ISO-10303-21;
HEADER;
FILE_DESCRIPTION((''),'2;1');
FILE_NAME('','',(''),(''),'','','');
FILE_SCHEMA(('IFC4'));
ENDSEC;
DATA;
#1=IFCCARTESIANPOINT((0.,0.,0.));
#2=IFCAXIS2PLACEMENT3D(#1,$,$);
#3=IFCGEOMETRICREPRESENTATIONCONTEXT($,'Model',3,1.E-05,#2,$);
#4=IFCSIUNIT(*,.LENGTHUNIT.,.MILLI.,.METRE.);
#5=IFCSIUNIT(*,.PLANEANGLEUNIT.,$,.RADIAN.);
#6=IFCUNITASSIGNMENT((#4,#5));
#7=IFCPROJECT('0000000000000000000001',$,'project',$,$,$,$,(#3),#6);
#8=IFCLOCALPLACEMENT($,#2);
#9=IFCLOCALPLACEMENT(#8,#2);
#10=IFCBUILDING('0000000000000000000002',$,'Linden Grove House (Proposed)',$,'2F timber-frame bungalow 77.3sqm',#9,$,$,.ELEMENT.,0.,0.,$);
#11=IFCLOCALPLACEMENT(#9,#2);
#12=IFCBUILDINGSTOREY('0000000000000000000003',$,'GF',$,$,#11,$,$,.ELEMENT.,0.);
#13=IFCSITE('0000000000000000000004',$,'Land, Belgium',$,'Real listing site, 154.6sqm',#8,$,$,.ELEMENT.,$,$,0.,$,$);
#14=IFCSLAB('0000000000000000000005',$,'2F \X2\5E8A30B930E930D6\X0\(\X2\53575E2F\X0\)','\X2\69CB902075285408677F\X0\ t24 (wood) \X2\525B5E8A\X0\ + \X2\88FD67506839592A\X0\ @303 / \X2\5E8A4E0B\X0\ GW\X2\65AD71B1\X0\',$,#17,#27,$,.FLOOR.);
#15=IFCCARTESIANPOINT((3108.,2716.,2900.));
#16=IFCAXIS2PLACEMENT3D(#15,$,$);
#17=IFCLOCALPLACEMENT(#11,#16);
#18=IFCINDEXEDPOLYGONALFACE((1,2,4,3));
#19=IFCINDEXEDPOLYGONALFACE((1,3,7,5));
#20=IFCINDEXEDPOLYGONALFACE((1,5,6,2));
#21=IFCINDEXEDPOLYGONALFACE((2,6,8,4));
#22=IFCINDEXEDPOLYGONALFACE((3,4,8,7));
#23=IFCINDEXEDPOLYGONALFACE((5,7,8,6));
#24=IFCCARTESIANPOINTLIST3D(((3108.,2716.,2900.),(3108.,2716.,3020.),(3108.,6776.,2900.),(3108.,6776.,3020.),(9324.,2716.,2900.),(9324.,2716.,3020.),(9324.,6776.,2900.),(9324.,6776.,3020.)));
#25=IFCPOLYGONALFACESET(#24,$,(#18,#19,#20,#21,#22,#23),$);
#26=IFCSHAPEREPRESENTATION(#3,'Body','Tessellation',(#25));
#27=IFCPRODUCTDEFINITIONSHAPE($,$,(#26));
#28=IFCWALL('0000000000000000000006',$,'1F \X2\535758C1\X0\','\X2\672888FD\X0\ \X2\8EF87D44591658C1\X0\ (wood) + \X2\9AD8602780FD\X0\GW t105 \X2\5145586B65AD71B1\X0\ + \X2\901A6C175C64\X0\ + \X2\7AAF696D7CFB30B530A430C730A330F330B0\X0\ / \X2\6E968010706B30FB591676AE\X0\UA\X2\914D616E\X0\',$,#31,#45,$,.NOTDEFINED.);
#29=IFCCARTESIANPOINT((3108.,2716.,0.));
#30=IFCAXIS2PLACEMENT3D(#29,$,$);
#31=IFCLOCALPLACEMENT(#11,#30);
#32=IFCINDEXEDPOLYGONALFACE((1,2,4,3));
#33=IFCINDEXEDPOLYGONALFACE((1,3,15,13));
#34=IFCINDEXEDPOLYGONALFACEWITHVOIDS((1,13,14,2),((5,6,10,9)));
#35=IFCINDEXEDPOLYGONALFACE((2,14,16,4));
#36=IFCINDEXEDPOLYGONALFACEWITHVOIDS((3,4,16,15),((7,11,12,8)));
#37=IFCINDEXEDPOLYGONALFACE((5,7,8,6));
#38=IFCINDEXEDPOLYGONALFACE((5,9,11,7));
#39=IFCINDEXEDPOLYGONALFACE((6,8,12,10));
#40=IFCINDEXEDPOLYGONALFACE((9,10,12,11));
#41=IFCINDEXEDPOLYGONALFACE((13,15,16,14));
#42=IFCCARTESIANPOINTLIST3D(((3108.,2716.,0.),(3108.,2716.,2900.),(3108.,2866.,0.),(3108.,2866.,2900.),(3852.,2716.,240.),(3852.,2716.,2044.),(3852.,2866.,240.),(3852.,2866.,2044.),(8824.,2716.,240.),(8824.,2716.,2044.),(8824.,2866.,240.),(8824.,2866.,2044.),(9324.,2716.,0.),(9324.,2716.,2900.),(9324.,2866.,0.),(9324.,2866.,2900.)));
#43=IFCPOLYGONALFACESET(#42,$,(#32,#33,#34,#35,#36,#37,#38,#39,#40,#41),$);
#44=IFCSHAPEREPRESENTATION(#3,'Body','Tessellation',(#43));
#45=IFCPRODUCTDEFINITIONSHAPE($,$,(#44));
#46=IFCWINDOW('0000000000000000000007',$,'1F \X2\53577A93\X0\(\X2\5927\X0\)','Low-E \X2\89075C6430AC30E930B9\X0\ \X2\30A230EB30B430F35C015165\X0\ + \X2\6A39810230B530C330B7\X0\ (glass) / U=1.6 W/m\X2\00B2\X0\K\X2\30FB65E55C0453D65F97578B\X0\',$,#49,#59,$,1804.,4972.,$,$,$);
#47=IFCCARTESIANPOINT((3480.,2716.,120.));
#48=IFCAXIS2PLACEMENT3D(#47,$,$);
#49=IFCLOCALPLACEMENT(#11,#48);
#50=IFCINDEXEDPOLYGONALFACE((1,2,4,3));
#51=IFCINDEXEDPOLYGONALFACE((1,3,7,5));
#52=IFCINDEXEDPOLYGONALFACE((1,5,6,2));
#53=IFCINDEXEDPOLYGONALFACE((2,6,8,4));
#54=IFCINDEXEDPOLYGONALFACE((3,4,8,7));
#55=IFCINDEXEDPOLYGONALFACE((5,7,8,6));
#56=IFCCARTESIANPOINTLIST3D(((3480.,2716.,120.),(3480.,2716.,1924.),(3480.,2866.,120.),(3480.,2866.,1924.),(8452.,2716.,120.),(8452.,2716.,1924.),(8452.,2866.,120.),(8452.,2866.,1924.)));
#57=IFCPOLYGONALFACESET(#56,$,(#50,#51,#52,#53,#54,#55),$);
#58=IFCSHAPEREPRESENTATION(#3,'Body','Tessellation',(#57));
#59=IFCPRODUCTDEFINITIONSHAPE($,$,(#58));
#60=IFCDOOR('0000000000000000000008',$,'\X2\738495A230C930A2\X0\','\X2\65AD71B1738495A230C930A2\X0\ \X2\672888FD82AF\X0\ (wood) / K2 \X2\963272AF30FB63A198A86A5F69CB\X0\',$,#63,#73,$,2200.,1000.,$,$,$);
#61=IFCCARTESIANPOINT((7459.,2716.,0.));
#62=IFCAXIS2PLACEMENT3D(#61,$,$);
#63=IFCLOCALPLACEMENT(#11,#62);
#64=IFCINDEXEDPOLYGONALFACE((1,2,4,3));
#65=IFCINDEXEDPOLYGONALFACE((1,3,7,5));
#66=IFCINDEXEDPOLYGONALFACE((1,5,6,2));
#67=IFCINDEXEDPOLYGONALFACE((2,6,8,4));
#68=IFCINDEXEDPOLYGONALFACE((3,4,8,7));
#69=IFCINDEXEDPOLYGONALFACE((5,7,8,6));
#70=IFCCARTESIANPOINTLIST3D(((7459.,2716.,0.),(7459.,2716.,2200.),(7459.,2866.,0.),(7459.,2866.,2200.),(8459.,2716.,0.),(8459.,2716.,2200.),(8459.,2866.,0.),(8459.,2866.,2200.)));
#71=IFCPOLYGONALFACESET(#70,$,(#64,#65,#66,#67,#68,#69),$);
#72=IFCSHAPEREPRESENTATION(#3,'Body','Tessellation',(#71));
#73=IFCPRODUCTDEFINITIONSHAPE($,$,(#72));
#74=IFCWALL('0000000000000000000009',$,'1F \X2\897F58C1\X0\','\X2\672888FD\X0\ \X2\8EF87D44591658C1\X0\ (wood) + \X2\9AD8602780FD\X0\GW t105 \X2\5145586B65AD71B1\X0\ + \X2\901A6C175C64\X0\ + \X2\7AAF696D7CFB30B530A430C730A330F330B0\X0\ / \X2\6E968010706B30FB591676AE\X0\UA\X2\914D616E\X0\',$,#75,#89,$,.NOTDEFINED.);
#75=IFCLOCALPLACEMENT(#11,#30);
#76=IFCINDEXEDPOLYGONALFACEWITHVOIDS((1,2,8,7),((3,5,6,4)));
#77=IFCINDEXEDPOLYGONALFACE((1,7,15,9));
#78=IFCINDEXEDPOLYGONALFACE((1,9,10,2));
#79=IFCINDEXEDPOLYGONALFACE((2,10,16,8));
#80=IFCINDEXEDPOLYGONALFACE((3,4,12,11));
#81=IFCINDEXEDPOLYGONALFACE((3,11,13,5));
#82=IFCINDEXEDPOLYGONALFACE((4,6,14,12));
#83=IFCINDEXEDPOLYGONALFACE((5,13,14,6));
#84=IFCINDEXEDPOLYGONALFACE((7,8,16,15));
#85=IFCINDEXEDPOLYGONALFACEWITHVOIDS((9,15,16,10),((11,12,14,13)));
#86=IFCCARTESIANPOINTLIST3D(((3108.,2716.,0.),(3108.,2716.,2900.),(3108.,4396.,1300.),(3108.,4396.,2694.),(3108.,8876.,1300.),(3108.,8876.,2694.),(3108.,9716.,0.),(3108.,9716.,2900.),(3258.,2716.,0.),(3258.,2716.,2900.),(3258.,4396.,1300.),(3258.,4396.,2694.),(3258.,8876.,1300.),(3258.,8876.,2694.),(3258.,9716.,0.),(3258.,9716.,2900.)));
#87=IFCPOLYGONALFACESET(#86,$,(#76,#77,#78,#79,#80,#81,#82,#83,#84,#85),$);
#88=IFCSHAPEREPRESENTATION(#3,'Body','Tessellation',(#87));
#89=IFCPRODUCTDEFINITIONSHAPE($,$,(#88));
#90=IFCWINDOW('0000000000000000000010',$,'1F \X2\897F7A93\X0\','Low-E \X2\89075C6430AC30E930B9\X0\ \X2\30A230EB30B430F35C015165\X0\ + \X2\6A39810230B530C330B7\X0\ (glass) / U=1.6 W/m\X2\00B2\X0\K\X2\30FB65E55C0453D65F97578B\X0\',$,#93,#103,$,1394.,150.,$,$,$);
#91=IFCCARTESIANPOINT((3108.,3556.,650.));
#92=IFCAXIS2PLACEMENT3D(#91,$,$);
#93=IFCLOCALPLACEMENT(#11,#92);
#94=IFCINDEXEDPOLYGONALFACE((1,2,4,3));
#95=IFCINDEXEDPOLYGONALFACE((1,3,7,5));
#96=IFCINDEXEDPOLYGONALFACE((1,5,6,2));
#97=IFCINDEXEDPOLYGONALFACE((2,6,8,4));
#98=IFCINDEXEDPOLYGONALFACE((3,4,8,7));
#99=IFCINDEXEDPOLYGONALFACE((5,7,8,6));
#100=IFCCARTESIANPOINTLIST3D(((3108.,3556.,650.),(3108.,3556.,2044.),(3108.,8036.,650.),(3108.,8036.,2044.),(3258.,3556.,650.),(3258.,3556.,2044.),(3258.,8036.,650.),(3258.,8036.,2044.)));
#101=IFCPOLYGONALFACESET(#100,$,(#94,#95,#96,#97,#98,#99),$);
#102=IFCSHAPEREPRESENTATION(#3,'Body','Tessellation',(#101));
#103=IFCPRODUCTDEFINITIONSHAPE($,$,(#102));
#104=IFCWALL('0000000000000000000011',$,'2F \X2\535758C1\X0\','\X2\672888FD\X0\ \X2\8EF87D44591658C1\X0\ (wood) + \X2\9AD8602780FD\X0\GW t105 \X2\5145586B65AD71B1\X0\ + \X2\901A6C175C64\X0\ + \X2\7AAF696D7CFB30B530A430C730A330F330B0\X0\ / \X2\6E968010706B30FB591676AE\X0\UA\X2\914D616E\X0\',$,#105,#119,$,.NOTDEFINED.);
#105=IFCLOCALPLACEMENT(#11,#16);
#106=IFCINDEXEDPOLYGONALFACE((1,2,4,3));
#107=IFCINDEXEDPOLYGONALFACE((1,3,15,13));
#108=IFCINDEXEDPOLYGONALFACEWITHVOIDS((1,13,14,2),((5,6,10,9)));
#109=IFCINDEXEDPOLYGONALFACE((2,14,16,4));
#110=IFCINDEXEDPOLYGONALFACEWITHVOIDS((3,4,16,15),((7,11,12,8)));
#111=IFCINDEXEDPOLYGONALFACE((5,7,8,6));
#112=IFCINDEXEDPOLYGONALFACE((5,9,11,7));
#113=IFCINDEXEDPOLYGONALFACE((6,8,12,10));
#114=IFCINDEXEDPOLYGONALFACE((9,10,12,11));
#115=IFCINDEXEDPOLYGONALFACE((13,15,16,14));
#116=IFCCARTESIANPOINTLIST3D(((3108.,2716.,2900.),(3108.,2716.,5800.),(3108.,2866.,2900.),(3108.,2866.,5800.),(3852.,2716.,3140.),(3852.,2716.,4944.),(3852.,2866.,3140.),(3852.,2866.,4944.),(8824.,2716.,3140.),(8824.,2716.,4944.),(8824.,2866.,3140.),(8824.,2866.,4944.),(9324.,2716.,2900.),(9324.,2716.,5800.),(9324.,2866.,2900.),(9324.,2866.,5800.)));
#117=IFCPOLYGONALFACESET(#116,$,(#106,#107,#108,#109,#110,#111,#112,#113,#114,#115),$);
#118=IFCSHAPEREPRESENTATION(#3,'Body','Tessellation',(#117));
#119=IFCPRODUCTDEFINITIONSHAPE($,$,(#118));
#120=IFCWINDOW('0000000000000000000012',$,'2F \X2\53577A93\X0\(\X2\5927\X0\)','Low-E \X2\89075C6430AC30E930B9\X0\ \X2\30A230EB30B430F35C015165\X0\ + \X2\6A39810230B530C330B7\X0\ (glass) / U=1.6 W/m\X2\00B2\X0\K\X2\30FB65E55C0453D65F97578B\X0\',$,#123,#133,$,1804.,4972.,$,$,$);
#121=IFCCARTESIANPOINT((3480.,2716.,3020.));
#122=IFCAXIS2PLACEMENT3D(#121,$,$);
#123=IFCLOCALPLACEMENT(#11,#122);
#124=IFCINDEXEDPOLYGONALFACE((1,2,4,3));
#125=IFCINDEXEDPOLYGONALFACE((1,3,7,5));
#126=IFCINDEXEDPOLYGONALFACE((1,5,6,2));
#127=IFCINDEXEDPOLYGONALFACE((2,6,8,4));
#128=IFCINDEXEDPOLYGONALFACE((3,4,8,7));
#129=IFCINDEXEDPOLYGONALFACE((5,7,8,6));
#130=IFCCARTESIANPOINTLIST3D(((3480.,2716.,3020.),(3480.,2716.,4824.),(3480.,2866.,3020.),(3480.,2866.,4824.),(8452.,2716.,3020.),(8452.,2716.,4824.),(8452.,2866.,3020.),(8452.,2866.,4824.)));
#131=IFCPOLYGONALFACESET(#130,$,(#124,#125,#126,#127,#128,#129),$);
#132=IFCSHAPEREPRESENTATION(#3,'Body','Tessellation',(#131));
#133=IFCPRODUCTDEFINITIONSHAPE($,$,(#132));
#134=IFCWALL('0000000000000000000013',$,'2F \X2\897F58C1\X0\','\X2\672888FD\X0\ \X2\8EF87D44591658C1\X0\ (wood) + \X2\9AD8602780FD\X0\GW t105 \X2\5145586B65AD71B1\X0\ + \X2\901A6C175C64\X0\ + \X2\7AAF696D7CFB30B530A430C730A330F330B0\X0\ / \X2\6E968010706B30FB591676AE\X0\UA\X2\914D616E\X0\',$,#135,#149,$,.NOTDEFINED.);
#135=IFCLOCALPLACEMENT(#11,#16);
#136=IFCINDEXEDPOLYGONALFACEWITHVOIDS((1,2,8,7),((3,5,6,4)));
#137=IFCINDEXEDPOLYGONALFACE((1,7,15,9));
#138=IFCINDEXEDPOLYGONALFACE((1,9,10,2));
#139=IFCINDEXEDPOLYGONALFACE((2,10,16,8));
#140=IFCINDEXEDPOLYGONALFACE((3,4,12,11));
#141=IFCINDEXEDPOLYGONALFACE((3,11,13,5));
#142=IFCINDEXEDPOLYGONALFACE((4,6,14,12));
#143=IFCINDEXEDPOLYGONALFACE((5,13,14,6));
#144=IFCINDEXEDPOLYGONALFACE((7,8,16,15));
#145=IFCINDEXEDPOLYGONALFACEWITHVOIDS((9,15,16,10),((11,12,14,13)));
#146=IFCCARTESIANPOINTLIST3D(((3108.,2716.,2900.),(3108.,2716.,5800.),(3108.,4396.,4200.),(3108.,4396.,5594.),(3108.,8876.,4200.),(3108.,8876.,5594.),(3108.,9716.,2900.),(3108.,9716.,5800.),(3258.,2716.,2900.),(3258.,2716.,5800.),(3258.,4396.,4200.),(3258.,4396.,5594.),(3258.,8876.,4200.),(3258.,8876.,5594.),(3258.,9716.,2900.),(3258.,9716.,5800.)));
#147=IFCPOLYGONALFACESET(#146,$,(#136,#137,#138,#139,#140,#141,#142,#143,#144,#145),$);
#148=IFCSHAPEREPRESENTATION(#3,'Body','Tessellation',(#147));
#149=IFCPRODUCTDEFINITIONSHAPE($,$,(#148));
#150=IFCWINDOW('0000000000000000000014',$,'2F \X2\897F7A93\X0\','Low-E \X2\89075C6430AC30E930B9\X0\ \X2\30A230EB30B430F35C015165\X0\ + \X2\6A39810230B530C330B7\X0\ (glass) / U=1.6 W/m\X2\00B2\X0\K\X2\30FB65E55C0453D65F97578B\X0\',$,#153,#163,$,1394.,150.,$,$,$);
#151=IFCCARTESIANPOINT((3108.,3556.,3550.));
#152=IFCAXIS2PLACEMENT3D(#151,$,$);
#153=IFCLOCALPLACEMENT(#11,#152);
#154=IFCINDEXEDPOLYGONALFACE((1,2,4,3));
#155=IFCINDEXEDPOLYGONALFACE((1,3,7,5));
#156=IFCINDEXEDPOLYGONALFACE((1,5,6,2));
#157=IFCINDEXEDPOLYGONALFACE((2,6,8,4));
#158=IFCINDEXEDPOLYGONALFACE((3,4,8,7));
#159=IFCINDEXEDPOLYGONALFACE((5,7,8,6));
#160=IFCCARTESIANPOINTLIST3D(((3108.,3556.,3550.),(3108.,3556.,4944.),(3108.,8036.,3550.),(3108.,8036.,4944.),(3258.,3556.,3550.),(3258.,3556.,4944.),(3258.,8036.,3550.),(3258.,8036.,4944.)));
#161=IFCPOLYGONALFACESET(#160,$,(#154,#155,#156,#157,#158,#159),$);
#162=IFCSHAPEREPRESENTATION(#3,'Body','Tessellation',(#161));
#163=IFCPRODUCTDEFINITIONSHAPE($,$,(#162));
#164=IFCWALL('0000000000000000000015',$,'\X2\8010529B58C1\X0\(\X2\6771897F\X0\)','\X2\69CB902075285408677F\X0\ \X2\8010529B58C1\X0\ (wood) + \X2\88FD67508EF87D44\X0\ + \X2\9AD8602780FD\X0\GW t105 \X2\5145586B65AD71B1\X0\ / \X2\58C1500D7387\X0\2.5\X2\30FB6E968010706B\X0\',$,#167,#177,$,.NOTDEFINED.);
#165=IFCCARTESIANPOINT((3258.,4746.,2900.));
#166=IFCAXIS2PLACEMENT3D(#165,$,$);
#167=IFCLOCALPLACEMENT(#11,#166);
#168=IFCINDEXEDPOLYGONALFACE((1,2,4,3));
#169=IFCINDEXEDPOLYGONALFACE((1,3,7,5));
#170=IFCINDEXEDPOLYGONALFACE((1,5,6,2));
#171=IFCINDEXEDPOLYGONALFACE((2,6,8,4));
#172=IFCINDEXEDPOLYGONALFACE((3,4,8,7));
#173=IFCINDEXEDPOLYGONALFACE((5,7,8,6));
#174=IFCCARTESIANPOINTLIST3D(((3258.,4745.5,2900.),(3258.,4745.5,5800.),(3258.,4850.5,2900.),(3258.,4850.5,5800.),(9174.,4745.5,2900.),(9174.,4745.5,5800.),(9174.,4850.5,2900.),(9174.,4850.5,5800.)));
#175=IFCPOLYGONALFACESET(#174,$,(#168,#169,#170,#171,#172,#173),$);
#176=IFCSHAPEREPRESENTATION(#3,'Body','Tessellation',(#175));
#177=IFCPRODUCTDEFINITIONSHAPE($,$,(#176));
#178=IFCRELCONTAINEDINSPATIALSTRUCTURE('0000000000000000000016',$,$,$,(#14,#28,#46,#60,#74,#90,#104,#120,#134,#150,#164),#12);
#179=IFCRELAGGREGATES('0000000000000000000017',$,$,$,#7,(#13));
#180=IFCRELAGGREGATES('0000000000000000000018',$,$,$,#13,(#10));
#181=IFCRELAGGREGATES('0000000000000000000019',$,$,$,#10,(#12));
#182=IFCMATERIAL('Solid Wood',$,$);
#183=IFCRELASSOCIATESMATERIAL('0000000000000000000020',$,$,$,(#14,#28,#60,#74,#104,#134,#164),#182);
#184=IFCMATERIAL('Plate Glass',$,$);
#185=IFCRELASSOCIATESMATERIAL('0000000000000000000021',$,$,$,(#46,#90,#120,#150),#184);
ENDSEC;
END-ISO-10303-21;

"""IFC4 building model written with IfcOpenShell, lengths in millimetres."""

from ifc_helpers import new_model, si_unit, frame, frame_2d, origin, place, context, project, spatial, rectangle, extrude, material, element, fill, save


model = new_model("IFC4")

# Units and contexts
model_context = context("Model", 3, precision=1e-05, world=origin())
ifc_project = project(units=[si_unit("LENGTHUNIT", "METRE", prefix="MILLI"), si_unit("PLANEANGLEUNIT", "RADIAN")], contexts=[model_context])

# Site, building, storey
site_placement = place(None, origin())
site = spatial("IfcSite", under=ifc_project, at=site_placement, Name="Land, Belgium", ObjectType="Real listing site, 154.6sqm", CompositionType="ELEMENT", RefElevation=0.0)
building_placement = place(site_placement, origin())
building = spatial("IfcBuilding", under=site, at=building_placement, Name="Linden Grove House (Proposed)", ObjectType="2F timber-frame bungalow 77.3sqm", CompositionType="ELEMENT", ElevationOfRefHeight=0.0, ElevationOfTerrain=0.0)
storey_placement = place(building_placement, origin())
storey = spatial("IfcBuildingStorey", under=building, at=storey_placement, Name="GF", CompositionType="ELEMENT", Elevation=0.0)

# Slab
ifc_material_1 = material(Name="Solid Wood")
slab_1_placement = place(storey_placement, frame((3108.0, 2716.0, 2900.0)))
element("IfcSlab", 1, at=slab_1_placement, inside=storey, material=ifc_material_1, Name="2F 床スラブ(南帯)", Description="構造用合板 t24 (wood) 剛床 + 製材根太 @303 / 床下 GW断熱", PredefinedType="FLOOR", context=model_context, shape_type="SweptSolid", body=[
    extrude(rectangle(XDim=6216.0, YDim=4060.0, at=frame_2d((3108.0, 2030.0))), frame((3108.0, 2716.0, 2900.0)), (0.0, 0.0, 1.0), 120.0),
])

# Wall, openings, window, door
wall_1_placement = place(storey_placement, frame((3108.0, 2716.0, 0.0)))
wall_1 = element("IfcWall", 2, at=wall_1_placement, inside=storey, material=ifc_material_1, Name="1F 南壁", Description="木製 軸組外壁 (wood) + 高性能GW t105 充填断熱 + 通気層 + 窯業系サイディング / 準耐火・外皮UA配慮", PredefinedType="NOTDEFINED", context=model_context, shape_type="SweptSolid", body=[
    extrude(rectangle(XDim=6216.0, YDim=150.0, at=frame_2d((3108.0, 75.0))), frame((3108.0, 2716.0, 0.0)), (0.0, 0.0, 1.0), 2900.0),
])
opening_1_placement = place(storey_placement, frame((3480.0, 2716.0, 120.0)))
opening_1 = element("IfcOpeningElement", 3, at=opening_1_placement, cuts=wall_1, PredefinedType="NOTDEFINED", context=model_context, shape_type="SweptSolid", body=[
    extrude(rectangle(XDim=4972.0, YDim=150.0, at=frame_2d((2486.0, 75.0))), frame((3480.0, 2716.0, 120.0)), (0.0, 0.0, 1.0), 1804.0),
])
opening_2_placement = place(storey_placement, frame((7459.0, 2716.0, 0.0)))
opening_2 = element("IfcOpeningElement", 4, at=opening_2_placement, cuts=wall_1, PredefinedType="NOTDEFINED", context=model_context, shape_type="SweptSolid", body=[
    extrude(rectangle(XDim=1000.0, YDim=150.0, at=frame_2d((500.0, 75.0))), frame((7459.0, 2716.0, 0.0)), (0.0, 0.0, 1.0), 2200.0),
])
ifc_material_2 = material(Name="Plate Glass")
window_1_placement = place(storey_placement, frame((3480.0, 2716.0, 120.0)))
window_1 = element("IfcWindow", 5, at=window_1_placement, inside=storey, material=ifc_material_2, Name="1F 南窓(大)", Description="Low-E 複層ガラス アルゴン封入 + 樹脂サッシ (glass) / U=1.6 W/m²K・日射取得型", OverallHeight=1804.0, OverallWidth=4972.0, context=model_context, shape_type="SweptSolid", body=[
    extrude(rectangle(XDim=4972.0, YDim=150.0, at=frame_2d((2486.0, 75.0))), frame((3480.0, 2716.0, 120.0)), (0.0, 0.0, 1.0), 1804.0),
])
fill(opening_1, window_1)
door_placement = place(storey_placement, frame((7459.0, 2716.0, 0.0)))
door = element("IfcDoor", 6, at=door_placement, inside=storey, material=ifc_material_1, Name="玄関ドア", Description="断熱玄関ドア 木製芯 (wood) / K2 防犯・採風機構", OverallHeight=2200.0, OverallWidth=1000.0, context=model_context, shape_type="SweptSolid", body=[
    extrude(rectangle(XDim=1000.0, YDim=150.0, at=frame_2d((500.0, 75.0))), frame((7459.0, 2716.0, 0.0)), (0.0, 0.0, 1.0), 2200.0),
])
fill(opening_2, door)

# Wall, opening, window
wall_2_placement = place(storey_placement, frame((3108.0, 2716.0, 0.0)))
wall_2 = element("IfcWall", 7, at=wall_2_placement, inside=storey, material=ifc_material_1, Name="1F 西壁", Description="木製 軸組外壁 (wood) + 高性能GW t105 充填断熱 + 通気層 + 窯業系サイディング / 準耐火・外皮UA配慮", PredefinedType="NOTDEFINED", context=model_context, shape_type="SweptSolid", body=[
    extrude(rectangle(XDim=150.0, YDim=7000.0, at=frame_2d((75.0, 3500.0))), frame((3108.0, 2716.0, 0.0)), (0.0, 0.0, 1.0), 2900.0),
])
opening_3_placement = place(storey_placement, frame((3108.0, 3556.0, 650.0)))
opening_3 = element("IfcOpeningElement", 8, at=opening_3_placement, cuts=wall_2, PredefinedType="NOTDEFINED", context=model_context, shape_type="SweptSolid", body=[
    extrude(rectangle(XDim=150.0, YDim=4480.0, at=frame_2d((75.0, 2240.0))), frame((3108.0, 3556.0, 650.0)), (0.0, 0.0, 1.0), 1394.0),
])
window_2_placement = place(storey_placement, frame((3108.0, 3556.0, 650.0)))
window_2 = element("IfcWindow", 9, at=window_2_placement, inside=storey, material=ifc_material_2, Name="1F 西窓", Description="Low-E 複層ガラス アルゴン封入 + 樹脂サッシ (glass) / U=1.6 W/m²K・日射取得型", OverallHeight=1394.0, OverallWidth=150.0, context=model_context, shape_type="SweptSolid", body=[
    extrude(rectangle(XDim=150.0, YDim=4480.0, at=frame_2d((75.0, 2240.0))), frame((3108.0, 3556.0, 650.0)), (0.0, 0.0, 1.0), 1394.0),
])
fill(opening_3, window_2)

# Walls, openings, windows
wall_3_placement = place(storey_placement, frame((3108.0, 2716.0, 2900.0)))
wall_3 = element("IfcWall", 10, at=wall_3_placement, inside=storey, material=ifc_material_1, Name="2F 南壁", Description="木製 軸組外壁 (wood) + 高性能GW t105 充填断熱 + 通気層 + 窯業系サイディング / 準耐火・外皮UA配慮", PredefinedType="NOTDEFINED", context=model_context, shape_type="SweptSolid", body=[
    extrude(rectangle(XDim=6216.0, YDim=150.0, at=frame_2d((3108.0, 75.0))), frame((3108.0, 2716.0, 2900.0)), (0.0, 0.0, 1.0), 2900.0),
])
opening_4_placement = place(storey_placement, frame((3480.0, 2716.0, 3020.0)))
opening_4 = element("IfcOpeningElement", 11, at=opening_4_placement, cuts=wall_3, PredefinedType="NOTDEFINED", context=model_context, shape_type="SweptSolid", body=[
    extrude(rectangle(XDim=4972.0, YDim=150.0, at=frame_2d((2486.0, 75.0))), frame((3480.0, 2716.0, 3020.0)), (0.0, 0.0, 1.0), 1804.0),
])
window_3_placement = place(storey_placement, frame((3480.0, 2716.0, 3020.0)))
window_3 = element("IfcWindow", 12, at=window_3_placement, inside=storey, material=ifc_material_2, Name="2F 南窓(大)", Description="Low-E 複層ガラス アルゴン封入 + 樹脂サッシ (glass) / U=1.6 W/m²K・日射取得型", OverallHeight=1804.0, OverallWidth=4972.0, context=model_context, shape_type="SweptSolid", body=[
    extrude(rectangle(XDim=4972.0, YDim=150.0, at=frame_2d((2486.0, 75.0))), frame((3480.0, 2716.0, 3020.0)), (0.0, 0.0, 1.0), 1804.0),
])
fill(opening_4, window_3)
wall_4_placement = place(storey_placement, frame((3108.0, 2716.0, 2900.0)))
wall_4 = element("IfcWall", 13, at=wall_4_placement, inside=storey, material=ifc_material_1, Name="2F 西壁", Description="木製 軸組外壁 (wood) + 高性能GW t105 充填断熱 + 通気層 + 窯業系サイディング / 準耐火・外皮UA配慮", PredefinedType="NOTDEFINED", context=model_context, shape_type="SweptSolid", body=[
    extrude(rectangle(XDim=150.0, YDim=7000.0, at=frame_2d((75.0, 3500.0))), frame((3108.0, 2716.0, 2900.0)), (0.0, 0.0, 1.0), 2900.0),
])
opening_5_placement = place(storey_placement, frame((3108.0, 3556.0, 3550.0)))
opening_5 = element("IfcOpeningElement", 14, at=opening_5_placement, cuts=wall_4, PredefinedType="NOTDEFINED", context=model_context, shape_type="SweptSolid", body=[
    extrude(rectangle(XDim=150.0, YDim=4480.0, at=frame_2d((75.0, 2240.0))), frame((3108.0, 3556.0, 3550.0)), (0.0, 0.0, 1.0), 1394.0),
])
window_4_placement = place(storey_placement, frame((3108.0, 3556.0, 3550.0)))
window_4 = element("IfcWindow", 15, at=window_4_placement, inside=storey, material=ifc_material_2, Name="2F 西窓", Description="Low-E 複層ガラス アルゴン封入 + 樹脂サッシ (glass) / U=1.6 W/m²K・日射取得型", OverallHeight=1394.0, OverallWidth=150.0, context=model_context, shape_type="SweptSolid", body=[
    extrude(rectangle(XDim=150.0, YDim=4480.0, at=frame_2d((75.0, 2240.0))), frame((3108.0, 3556.0, 3550.0)), (0.0, 0.0, 1.0), 1394.0),
])
fill(opening_5, window_4)

# Wall
wall_5_placement = place(storey_placement, frame((3258.0, 4746.0, 2900.0)))
element("IfcWall", 16, at=wall_5_placement, inside=storey, material=ifc_material_1, Name="耐力壁(東西)", Description="構造用合板 耐力壁 (wood) + 製材軸組 + 高性能GW t105 充填断熱 / 壁倍率2.5・準耐火", PredefinedType="NOTDEFINED", context=model_context, shape_type="SweptSolid", body=[
    extrude(rectangle(XDim=5916.0, YDim=105.0, at=frame_2d((2958.0, 52.0))), frame((3258.0, 4746.0, 2900.0)), (0.0, 0.0, 1.0), 2900.0),
])

save(model, "model.ifc")
